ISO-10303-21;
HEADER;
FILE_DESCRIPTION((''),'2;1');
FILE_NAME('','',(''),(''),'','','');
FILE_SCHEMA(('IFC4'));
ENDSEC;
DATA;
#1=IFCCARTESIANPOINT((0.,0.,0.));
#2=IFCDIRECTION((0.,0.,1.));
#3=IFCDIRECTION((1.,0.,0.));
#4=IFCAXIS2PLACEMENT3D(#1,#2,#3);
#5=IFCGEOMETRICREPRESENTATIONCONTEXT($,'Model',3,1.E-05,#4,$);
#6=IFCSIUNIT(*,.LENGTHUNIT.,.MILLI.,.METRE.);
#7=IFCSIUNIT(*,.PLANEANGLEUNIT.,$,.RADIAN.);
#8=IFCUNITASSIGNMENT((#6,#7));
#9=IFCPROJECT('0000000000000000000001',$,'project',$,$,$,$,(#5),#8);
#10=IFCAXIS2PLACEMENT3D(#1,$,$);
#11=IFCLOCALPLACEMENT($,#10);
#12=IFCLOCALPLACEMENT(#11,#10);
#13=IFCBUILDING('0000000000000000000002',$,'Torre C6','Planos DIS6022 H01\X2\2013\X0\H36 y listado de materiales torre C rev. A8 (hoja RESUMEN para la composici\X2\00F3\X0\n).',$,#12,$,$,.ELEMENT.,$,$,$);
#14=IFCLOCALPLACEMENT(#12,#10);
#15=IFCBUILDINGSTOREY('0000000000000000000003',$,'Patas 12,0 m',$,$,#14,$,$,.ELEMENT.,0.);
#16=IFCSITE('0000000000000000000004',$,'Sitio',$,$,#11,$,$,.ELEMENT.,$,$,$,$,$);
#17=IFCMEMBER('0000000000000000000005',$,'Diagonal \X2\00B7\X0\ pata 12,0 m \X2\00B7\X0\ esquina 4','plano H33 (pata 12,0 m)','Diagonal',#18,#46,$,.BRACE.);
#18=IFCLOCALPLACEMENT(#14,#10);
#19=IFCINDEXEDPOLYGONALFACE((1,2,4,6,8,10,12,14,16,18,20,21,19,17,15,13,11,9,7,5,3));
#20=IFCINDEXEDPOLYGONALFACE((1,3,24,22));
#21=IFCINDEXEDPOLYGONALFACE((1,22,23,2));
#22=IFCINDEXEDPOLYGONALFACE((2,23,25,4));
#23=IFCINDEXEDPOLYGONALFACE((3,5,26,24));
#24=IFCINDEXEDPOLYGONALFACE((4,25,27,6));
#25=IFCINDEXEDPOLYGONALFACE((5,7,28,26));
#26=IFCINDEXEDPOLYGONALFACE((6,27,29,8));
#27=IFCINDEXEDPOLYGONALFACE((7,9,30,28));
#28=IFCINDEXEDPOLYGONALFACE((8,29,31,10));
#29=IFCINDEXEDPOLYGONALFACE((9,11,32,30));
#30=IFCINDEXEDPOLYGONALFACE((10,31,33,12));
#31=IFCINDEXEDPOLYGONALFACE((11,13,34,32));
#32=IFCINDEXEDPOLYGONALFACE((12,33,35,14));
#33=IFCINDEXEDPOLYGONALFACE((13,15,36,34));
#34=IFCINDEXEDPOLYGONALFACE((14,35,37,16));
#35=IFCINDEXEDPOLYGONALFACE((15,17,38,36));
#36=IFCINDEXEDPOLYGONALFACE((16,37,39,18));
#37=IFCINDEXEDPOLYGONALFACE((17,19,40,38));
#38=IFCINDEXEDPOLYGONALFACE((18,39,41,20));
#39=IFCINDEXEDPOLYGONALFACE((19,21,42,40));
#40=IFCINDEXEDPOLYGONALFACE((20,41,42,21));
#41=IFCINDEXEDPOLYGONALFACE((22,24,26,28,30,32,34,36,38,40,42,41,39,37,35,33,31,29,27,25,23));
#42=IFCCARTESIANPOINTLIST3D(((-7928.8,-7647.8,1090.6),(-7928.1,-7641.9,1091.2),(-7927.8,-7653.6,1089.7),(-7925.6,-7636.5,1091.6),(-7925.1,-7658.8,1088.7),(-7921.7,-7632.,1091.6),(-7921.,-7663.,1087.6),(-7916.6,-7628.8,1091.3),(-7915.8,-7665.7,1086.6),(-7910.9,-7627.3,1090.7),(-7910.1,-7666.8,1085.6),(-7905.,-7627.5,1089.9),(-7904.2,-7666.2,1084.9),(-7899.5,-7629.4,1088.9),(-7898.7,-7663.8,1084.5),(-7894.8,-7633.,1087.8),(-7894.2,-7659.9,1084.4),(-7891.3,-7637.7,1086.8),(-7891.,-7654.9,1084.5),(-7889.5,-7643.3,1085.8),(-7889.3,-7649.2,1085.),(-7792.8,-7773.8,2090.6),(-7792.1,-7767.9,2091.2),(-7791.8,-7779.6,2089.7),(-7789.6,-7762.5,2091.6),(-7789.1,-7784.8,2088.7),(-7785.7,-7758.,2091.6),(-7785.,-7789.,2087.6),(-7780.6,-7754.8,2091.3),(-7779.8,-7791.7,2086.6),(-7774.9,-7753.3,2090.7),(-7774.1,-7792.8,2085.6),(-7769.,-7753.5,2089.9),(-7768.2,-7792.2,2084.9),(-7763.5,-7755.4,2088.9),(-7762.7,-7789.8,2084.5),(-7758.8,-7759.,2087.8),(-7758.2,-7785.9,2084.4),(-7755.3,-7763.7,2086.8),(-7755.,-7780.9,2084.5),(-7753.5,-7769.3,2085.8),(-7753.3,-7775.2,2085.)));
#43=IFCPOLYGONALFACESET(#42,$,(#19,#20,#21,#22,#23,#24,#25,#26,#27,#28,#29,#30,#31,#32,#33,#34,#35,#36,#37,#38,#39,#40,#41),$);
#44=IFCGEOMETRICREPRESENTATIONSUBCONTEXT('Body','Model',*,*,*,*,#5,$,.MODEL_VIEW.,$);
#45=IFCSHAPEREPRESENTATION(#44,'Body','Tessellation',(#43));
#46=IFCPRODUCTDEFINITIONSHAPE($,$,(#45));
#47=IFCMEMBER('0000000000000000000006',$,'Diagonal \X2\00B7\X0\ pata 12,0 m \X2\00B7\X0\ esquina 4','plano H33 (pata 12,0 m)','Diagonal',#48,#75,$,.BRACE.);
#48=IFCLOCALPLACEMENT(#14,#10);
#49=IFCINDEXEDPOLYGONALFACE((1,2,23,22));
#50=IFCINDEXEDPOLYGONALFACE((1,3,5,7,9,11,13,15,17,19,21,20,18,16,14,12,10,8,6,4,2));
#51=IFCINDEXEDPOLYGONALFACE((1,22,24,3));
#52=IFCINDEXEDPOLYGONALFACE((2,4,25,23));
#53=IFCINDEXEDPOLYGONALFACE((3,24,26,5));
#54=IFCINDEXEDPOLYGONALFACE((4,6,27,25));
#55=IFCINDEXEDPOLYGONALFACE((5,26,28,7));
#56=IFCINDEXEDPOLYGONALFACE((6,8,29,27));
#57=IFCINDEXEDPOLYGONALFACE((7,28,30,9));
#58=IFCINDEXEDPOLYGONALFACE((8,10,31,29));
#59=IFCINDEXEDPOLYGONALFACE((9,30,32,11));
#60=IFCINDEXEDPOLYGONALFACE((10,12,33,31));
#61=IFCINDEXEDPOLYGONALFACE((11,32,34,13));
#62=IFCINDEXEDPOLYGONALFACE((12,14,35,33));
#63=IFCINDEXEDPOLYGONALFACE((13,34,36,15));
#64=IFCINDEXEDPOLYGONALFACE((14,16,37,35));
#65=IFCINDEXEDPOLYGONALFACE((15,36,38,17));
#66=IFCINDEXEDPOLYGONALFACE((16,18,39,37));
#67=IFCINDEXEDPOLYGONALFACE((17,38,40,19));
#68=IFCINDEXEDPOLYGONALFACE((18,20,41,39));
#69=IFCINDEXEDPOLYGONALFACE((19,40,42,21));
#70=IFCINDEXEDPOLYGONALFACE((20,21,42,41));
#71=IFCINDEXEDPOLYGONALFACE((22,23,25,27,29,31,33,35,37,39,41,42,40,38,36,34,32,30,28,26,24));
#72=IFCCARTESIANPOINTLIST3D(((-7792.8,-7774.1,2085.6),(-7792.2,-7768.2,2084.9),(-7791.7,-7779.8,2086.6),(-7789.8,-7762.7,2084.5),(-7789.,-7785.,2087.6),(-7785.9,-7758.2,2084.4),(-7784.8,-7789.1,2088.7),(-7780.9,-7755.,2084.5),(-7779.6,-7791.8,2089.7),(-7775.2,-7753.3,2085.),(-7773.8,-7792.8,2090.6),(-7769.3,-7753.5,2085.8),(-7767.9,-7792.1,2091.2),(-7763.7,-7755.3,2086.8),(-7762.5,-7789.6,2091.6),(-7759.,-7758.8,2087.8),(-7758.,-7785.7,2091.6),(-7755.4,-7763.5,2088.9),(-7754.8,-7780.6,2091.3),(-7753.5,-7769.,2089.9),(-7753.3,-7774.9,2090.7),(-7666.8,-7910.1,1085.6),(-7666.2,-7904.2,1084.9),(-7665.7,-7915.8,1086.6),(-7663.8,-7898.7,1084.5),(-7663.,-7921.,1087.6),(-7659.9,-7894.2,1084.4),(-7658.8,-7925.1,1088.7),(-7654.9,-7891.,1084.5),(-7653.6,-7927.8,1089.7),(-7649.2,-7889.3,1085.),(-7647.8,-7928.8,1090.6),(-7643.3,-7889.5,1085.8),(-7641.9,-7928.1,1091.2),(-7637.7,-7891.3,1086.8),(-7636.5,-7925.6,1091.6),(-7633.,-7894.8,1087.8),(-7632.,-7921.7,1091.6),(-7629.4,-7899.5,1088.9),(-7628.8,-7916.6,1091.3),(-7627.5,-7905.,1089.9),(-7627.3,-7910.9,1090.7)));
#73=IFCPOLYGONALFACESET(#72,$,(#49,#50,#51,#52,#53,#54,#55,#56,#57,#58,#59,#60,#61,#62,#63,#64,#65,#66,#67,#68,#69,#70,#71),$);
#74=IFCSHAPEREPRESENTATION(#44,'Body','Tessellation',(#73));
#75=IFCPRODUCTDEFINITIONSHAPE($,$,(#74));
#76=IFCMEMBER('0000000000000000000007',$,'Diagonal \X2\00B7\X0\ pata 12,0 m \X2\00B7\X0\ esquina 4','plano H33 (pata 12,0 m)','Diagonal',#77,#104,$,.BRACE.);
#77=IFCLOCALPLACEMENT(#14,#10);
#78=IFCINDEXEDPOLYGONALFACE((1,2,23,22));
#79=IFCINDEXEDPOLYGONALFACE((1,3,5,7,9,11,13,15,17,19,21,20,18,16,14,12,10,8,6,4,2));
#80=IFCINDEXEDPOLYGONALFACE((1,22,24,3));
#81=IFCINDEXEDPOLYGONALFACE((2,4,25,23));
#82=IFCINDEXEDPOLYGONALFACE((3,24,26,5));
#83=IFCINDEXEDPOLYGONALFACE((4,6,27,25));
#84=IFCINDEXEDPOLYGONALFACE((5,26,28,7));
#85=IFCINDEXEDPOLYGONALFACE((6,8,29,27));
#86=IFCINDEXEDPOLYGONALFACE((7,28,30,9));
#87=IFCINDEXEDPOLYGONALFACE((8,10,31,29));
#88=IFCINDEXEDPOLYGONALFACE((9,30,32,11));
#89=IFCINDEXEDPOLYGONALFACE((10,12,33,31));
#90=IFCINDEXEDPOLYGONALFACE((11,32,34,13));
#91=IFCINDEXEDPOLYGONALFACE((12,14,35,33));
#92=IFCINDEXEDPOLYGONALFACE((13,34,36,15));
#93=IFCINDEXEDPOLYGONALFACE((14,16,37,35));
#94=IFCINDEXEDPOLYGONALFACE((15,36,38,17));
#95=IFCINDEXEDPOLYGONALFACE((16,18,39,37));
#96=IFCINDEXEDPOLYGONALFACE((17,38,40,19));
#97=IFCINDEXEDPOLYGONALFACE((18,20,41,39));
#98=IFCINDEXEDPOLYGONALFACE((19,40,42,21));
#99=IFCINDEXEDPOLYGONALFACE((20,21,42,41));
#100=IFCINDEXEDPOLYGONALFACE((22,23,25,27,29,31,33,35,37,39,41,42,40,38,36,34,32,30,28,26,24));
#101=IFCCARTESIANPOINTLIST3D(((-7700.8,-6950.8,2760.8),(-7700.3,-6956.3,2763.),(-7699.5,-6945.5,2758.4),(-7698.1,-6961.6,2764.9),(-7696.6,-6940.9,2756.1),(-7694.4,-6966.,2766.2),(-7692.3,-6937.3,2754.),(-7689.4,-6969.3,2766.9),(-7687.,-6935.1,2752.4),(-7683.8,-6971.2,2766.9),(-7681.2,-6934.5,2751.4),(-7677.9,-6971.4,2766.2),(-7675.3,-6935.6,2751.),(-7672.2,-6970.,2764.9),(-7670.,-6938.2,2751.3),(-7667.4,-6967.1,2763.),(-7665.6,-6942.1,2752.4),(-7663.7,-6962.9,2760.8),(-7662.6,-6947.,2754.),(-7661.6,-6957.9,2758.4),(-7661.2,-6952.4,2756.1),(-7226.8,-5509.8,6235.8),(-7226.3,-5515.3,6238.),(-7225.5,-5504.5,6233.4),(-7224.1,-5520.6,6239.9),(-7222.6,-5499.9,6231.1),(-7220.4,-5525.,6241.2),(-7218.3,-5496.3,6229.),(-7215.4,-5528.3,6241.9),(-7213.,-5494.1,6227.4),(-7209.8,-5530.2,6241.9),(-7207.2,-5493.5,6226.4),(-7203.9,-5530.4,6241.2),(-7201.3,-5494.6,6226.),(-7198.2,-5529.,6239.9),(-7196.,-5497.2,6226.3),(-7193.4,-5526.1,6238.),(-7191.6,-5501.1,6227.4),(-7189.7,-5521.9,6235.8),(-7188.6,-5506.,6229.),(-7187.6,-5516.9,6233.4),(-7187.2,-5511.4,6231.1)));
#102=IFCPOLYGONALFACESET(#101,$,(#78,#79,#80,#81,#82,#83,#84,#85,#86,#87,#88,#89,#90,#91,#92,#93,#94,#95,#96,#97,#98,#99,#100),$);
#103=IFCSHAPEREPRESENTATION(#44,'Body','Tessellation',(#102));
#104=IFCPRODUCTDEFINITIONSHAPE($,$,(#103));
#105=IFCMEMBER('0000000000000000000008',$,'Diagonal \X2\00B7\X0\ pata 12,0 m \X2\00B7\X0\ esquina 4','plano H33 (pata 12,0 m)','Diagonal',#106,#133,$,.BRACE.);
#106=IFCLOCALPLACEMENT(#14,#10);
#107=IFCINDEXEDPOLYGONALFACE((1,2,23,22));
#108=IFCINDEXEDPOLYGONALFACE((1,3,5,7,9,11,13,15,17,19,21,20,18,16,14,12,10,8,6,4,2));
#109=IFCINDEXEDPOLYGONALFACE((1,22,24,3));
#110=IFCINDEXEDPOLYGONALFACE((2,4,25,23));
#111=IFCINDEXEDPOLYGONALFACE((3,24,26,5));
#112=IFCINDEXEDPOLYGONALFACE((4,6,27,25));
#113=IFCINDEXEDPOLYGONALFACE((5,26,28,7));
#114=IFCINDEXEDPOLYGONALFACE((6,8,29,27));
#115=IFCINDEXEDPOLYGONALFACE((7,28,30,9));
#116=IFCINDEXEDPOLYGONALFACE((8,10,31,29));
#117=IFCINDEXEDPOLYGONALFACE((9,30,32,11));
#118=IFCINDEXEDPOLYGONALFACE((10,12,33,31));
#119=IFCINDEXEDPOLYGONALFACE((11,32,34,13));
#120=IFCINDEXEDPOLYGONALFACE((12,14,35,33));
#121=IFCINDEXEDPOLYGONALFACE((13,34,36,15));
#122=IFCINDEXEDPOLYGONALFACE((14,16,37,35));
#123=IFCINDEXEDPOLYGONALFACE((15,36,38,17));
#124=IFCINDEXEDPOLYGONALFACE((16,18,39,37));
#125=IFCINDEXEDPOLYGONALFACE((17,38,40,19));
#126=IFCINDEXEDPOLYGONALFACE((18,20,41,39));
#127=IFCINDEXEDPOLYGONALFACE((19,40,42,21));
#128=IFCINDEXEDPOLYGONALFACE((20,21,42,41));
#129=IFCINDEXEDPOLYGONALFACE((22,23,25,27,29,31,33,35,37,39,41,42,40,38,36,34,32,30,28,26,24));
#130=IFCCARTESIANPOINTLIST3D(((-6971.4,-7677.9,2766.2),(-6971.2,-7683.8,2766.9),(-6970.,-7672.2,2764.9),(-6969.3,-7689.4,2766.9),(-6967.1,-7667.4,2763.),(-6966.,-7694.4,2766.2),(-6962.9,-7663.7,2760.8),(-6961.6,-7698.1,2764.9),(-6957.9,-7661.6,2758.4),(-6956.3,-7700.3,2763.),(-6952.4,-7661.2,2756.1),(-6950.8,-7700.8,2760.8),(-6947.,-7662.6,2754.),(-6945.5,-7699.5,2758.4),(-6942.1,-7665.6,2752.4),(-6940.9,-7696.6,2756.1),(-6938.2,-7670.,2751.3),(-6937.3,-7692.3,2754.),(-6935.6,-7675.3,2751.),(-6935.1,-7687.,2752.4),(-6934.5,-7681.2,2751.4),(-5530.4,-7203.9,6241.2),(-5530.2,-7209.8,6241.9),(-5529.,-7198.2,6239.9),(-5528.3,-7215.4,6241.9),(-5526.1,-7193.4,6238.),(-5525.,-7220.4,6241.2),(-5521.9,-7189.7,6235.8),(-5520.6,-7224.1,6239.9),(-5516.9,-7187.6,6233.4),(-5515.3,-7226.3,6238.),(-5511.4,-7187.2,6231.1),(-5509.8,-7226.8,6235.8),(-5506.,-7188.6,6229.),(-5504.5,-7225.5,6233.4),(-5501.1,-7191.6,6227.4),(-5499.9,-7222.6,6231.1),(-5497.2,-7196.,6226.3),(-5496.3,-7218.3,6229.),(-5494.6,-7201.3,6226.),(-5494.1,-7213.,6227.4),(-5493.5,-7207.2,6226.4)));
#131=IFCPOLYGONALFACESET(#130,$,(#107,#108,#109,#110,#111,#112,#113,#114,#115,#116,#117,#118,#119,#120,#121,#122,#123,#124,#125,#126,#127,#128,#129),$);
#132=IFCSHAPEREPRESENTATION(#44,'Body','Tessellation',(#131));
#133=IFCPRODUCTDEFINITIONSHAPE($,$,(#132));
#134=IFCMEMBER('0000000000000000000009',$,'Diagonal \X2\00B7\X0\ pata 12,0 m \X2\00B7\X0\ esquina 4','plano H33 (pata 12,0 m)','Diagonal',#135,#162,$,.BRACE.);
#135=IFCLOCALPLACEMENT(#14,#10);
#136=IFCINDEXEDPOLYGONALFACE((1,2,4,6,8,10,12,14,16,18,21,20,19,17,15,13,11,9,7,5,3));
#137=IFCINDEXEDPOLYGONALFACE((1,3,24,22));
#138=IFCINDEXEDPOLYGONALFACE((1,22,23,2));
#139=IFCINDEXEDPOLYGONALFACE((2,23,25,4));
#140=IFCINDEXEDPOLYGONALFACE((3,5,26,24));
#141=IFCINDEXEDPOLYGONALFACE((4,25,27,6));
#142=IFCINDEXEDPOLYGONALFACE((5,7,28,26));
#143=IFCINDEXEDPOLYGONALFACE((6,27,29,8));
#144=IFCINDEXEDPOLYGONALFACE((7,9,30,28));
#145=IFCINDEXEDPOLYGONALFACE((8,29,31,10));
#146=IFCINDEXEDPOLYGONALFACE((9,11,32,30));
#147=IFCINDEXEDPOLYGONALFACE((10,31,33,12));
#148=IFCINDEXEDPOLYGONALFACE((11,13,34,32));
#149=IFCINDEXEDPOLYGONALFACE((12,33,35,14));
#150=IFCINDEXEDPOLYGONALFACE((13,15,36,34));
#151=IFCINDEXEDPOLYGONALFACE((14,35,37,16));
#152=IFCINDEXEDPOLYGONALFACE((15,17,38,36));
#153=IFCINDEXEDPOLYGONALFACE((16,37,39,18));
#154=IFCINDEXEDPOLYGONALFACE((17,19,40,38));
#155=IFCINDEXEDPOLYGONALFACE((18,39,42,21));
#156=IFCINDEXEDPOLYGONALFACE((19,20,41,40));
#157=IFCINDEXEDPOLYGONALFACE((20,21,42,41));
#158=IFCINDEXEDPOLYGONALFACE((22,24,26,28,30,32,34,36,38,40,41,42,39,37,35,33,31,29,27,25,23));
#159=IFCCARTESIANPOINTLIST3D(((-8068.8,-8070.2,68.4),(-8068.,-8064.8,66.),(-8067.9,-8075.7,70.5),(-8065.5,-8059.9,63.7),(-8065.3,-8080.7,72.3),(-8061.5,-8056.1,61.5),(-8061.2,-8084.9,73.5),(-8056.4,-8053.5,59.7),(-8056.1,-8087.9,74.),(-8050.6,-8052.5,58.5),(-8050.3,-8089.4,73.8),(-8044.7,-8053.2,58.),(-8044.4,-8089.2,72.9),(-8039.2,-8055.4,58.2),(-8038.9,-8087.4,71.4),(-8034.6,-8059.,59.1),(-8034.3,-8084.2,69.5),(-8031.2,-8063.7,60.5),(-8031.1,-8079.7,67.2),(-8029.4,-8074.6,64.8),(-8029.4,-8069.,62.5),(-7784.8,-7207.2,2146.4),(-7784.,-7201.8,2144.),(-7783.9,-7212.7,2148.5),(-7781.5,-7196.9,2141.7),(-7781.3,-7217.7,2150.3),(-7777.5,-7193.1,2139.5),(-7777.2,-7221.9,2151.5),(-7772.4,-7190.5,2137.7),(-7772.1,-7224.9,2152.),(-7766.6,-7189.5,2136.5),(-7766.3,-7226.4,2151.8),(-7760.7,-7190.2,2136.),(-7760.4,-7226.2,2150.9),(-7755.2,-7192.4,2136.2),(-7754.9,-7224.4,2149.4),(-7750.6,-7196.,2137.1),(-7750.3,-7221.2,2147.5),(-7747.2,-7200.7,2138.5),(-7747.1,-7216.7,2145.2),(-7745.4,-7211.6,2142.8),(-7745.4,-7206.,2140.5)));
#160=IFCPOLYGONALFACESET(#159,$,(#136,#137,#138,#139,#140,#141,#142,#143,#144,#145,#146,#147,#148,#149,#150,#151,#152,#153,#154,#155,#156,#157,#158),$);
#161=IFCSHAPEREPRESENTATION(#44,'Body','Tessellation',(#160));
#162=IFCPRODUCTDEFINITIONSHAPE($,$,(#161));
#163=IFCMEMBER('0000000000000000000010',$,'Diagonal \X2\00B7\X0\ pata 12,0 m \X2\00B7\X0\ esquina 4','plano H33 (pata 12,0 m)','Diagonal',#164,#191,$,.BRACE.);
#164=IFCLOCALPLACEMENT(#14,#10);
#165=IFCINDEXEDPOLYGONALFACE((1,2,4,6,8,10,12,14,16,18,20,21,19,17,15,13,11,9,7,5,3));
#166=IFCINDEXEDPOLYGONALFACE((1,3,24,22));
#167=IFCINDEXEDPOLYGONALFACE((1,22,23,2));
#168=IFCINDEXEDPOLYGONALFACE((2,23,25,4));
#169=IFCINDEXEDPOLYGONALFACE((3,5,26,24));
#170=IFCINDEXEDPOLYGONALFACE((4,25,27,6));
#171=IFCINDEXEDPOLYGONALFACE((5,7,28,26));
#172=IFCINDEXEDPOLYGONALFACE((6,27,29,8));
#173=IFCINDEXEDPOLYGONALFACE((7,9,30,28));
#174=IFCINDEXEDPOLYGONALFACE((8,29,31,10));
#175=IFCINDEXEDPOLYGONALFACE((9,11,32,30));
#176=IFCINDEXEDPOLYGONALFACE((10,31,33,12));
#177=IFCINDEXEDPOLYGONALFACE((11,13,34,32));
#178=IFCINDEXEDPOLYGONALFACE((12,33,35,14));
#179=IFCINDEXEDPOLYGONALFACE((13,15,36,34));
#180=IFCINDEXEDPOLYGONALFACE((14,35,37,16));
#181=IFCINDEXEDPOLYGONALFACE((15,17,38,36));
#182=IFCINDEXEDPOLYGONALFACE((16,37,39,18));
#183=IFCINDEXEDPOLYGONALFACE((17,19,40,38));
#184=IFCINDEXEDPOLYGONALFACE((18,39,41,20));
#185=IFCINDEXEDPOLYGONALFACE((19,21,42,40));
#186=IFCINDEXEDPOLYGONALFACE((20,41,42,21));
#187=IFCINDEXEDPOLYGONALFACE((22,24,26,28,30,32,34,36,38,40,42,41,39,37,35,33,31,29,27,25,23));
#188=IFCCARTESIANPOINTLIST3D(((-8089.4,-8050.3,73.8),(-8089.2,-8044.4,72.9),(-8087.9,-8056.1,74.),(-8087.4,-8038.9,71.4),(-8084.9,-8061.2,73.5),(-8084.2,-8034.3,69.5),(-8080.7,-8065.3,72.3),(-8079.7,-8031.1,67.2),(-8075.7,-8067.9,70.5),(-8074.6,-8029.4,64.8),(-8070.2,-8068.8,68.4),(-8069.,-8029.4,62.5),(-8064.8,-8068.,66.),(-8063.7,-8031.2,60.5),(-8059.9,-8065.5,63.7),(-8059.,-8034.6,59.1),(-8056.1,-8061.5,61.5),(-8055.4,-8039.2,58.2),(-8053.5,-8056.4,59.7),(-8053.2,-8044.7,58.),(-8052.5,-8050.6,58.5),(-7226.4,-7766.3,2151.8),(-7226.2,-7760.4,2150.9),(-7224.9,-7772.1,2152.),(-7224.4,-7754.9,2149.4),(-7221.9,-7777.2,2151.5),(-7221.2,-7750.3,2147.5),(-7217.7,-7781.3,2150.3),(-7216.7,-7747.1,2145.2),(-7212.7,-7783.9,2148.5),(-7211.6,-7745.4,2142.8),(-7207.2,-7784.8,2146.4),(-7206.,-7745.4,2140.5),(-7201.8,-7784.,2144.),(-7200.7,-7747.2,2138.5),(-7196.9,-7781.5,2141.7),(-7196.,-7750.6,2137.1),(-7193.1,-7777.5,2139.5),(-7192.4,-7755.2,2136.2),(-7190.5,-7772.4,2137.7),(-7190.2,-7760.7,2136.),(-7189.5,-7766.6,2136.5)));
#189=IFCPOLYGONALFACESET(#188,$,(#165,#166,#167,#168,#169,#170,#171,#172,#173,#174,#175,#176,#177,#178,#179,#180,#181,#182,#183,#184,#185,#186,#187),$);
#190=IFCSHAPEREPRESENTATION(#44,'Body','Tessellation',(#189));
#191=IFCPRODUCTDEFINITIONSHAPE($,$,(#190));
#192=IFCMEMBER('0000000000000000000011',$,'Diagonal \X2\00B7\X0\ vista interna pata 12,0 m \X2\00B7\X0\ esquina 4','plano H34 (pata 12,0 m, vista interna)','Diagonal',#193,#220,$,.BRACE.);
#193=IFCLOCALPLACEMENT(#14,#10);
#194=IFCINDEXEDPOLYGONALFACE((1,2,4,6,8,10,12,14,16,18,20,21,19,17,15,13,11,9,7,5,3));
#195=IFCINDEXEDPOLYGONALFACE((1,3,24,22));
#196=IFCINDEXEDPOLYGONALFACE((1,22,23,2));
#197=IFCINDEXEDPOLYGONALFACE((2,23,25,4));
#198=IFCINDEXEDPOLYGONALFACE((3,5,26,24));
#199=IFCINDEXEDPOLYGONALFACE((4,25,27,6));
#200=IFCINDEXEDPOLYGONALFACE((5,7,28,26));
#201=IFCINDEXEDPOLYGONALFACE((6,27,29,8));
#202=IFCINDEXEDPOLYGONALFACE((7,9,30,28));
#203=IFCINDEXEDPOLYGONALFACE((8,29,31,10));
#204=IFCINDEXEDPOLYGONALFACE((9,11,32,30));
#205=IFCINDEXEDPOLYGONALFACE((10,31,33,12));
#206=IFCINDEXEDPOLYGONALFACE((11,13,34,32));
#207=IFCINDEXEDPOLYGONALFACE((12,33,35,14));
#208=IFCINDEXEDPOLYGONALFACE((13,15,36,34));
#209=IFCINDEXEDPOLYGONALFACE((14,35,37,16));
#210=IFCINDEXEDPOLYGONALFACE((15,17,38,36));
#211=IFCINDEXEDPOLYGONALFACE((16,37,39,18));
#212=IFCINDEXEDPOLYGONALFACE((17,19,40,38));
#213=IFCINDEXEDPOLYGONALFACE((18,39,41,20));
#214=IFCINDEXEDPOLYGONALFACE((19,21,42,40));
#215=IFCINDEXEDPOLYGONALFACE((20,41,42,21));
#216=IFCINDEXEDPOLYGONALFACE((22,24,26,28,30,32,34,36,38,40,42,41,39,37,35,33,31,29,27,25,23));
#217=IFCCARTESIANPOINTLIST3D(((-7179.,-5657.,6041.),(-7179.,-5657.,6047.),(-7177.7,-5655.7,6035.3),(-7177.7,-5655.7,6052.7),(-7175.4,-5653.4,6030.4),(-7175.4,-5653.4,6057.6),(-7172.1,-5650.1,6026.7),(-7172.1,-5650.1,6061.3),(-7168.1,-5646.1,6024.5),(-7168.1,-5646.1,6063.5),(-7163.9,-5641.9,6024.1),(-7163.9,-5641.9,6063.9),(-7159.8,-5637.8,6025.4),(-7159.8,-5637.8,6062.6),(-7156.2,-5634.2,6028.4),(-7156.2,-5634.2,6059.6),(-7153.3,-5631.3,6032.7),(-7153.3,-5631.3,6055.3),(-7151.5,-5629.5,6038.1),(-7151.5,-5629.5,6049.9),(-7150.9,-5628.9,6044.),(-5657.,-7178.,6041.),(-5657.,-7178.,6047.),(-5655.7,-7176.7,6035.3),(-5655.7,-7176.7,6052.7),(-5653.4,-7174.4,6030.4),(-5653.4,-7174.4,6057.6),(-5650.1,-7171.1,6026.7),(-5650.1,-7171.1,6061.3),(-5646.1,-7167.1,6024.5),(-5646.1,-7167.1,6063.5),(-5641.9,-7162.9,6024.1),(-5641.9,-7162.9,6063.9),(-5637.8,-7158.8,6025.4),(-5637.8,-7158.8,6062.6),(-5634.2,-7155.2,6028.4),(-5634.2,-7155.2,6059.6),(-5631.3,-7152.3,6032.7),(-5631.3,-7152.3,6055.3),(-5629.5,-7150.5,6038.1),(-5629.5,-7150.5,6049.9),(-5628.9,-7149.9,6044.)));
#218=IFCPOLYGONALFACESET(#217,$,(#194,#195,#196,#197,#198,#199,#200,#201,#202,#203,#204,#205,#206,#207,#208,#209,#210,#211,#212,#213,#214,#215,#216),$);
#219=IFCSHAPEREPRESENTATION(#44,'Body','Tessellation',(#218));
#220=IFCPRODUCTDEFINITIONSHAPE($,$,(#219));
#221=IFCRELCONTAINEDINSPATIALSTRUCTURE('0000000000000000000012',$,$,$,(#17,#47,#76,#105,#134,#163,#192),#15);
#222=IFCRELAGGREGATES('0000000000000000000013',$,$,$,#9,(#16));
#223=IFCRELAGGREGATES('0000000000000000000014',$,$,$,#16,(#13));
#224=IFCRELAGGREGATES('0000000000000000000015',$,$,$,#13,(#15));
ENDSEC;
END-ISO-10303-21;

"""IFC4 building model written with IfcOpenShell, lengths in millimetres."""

from ifc_helpers import new_model, si_unit, frame, origin, origin_with_axes, place, context, subcontext, project, spatial, circle, extrude, element, save


model = new_model("IFC4")

# Units and contexts
model_context = context("Model", 3, precision=1e-05, world=origin_with_axes())
body_context = subcontext(model_context, "Body", "Model", "MODEL_VIEW")
ifc_project = project(units=[si_unit("LENGTHUNIT", "METRE", prefix="MILLI"), si_unit("PLANEANGLEUNIT", "RADIAN")], contexts=[model_context])

# Site, building, storey
site_placement = place(None, origin())
site = spatial("IfcSite", under=ifc_project, at=site_placement, Name="Sitio", CompositionType="ELEMENT")
building_placement = place(site_placement, origin())
building = spatial("IfcBuilding", under=site, at=building_placement, Name="Torre C6", Description="Planos DIS6022 H01–H36 y listado de materiales torre C rev. A8 (hoja RESUMEN para la composición).", CompositionType="ELEMENT")
storey_placement = place(building_placement, origin())
storey = spatial("IfcBuildingStorey", under=building, at=storey_placement, Name="Patas 12,0 m", CompositionType="ELEMENT", Elevation=0.0)

# Members
for number, where, z_axis, x_axis, name in (
    (1, (-7773.0, -7773.0, 2088.0), (-0.133721, 0.123889, -0.983245), (0.711929, 0.702202, -0.008345), "Diagonal · pata 12,0 m · esquina 4"),
    (2, (-7773.0, -7773.0, 2088.0), (0.123889, -0.133721, -0.983245), (0.702202, 0.711929, -0.008345), "Diagonal · pata 12,0 m · esquina 4"),
):
    element("IfcMember", number, at=place(storey_placement, frame(where, z_axis=z_axis, x_axis=x_axis)), inside=storey, Name=name, Description="plano H33 (pata 12,0 m)", ObjectType="Diagonal", PredefinedType="BRACE", context=body_context, shape_type="SweptSolid", body=[
        extrude(circle(Radius=20.0), None, (0.0, 0.0, 1.0), 1017.0),
    ])
for number, where, z_axis, x_axis, name in (
    (3, (-7207.0, -5512.0, 6234.0), (-0.125011, -0.380043, -0.916482), (0.770088, 0.545257, -0.331147), "Diagonal · pata 12,0 m · esquina 4"),
    (4, (-5512.0, -7207.0, 6234.0), (-0.380043, -0.125011, -0.916482), (0.545257, 0.770088, -0.331147), "Diagonal · pata 12,0 m · esquina 4"),
):
    element("IfcMember", number, at=place(storey_placement, frame(where, z_axis=z_axis, x_axis=x_axis)), inside=storey, Name=name, Description="plano H33 (pata 12,0 m)", ObjectType="Diagonal", PredefinedType="BRACE", context=body_context, shape_type="SweptSolid", body=[
        extrude(circle(Radius=20.0), None, (0.0, 0.0, 1.0), 3791.7),
    ])
for number, where, z_axis, x_axis, name in (
    (5, (-7765.0, -7208.0, 2144.0), (-0.125224, -0.380523, -0.916254), (0.721635, 0.598839, -0.347325), "Diagonal · pata 12,0 m · esquina 4"),
    (6, (-7208.0, -7765.0, 2144.0), (-0.380523, -0.125224, -0.916254), (0.598839, 0.721635, -0.347325), "Diagonal · pata 12,0 m · esquina 4"),
):
    element("IfcMember", number, at=place(storey_placement, frame(where, z_axis=z_axis, x_axis=x_axis)), inside=storey, Name=name, Description="plano H33 (pata 12,0 m)", ObjectType="Diagonal", PredefinedType="BRACE", context=body_context, shape_type="SweptSolid", body=[
        extrude(circle(Radius=20.0), None, (0.0, 0.0, 1.0), 2267.9),
    ])
member_1_placement = place(storey_placement, frame((-7165.0, -5643.0, 6044.0), z_axis=(0.707339, -0.706874, 0.0), x_axis=(0.706874, 0.707339, 0.0)))
element("IfcMember", 7, at=member_1_placement, inside=storey, Name="Diagonal · vista interna pata 12,0 m · esquina 4", Description="plano H34 (pata 12,0 m, vista interna)", ObjectType="Diagonal", PredefinedType="BRACE", context=body_context, shape_type="SweptSolid", body=[
    extrude(circle(Radius=20.0), None, (0.0, 0.0, 1.0), 2151.7),
])

save(model, "model.ifc")
